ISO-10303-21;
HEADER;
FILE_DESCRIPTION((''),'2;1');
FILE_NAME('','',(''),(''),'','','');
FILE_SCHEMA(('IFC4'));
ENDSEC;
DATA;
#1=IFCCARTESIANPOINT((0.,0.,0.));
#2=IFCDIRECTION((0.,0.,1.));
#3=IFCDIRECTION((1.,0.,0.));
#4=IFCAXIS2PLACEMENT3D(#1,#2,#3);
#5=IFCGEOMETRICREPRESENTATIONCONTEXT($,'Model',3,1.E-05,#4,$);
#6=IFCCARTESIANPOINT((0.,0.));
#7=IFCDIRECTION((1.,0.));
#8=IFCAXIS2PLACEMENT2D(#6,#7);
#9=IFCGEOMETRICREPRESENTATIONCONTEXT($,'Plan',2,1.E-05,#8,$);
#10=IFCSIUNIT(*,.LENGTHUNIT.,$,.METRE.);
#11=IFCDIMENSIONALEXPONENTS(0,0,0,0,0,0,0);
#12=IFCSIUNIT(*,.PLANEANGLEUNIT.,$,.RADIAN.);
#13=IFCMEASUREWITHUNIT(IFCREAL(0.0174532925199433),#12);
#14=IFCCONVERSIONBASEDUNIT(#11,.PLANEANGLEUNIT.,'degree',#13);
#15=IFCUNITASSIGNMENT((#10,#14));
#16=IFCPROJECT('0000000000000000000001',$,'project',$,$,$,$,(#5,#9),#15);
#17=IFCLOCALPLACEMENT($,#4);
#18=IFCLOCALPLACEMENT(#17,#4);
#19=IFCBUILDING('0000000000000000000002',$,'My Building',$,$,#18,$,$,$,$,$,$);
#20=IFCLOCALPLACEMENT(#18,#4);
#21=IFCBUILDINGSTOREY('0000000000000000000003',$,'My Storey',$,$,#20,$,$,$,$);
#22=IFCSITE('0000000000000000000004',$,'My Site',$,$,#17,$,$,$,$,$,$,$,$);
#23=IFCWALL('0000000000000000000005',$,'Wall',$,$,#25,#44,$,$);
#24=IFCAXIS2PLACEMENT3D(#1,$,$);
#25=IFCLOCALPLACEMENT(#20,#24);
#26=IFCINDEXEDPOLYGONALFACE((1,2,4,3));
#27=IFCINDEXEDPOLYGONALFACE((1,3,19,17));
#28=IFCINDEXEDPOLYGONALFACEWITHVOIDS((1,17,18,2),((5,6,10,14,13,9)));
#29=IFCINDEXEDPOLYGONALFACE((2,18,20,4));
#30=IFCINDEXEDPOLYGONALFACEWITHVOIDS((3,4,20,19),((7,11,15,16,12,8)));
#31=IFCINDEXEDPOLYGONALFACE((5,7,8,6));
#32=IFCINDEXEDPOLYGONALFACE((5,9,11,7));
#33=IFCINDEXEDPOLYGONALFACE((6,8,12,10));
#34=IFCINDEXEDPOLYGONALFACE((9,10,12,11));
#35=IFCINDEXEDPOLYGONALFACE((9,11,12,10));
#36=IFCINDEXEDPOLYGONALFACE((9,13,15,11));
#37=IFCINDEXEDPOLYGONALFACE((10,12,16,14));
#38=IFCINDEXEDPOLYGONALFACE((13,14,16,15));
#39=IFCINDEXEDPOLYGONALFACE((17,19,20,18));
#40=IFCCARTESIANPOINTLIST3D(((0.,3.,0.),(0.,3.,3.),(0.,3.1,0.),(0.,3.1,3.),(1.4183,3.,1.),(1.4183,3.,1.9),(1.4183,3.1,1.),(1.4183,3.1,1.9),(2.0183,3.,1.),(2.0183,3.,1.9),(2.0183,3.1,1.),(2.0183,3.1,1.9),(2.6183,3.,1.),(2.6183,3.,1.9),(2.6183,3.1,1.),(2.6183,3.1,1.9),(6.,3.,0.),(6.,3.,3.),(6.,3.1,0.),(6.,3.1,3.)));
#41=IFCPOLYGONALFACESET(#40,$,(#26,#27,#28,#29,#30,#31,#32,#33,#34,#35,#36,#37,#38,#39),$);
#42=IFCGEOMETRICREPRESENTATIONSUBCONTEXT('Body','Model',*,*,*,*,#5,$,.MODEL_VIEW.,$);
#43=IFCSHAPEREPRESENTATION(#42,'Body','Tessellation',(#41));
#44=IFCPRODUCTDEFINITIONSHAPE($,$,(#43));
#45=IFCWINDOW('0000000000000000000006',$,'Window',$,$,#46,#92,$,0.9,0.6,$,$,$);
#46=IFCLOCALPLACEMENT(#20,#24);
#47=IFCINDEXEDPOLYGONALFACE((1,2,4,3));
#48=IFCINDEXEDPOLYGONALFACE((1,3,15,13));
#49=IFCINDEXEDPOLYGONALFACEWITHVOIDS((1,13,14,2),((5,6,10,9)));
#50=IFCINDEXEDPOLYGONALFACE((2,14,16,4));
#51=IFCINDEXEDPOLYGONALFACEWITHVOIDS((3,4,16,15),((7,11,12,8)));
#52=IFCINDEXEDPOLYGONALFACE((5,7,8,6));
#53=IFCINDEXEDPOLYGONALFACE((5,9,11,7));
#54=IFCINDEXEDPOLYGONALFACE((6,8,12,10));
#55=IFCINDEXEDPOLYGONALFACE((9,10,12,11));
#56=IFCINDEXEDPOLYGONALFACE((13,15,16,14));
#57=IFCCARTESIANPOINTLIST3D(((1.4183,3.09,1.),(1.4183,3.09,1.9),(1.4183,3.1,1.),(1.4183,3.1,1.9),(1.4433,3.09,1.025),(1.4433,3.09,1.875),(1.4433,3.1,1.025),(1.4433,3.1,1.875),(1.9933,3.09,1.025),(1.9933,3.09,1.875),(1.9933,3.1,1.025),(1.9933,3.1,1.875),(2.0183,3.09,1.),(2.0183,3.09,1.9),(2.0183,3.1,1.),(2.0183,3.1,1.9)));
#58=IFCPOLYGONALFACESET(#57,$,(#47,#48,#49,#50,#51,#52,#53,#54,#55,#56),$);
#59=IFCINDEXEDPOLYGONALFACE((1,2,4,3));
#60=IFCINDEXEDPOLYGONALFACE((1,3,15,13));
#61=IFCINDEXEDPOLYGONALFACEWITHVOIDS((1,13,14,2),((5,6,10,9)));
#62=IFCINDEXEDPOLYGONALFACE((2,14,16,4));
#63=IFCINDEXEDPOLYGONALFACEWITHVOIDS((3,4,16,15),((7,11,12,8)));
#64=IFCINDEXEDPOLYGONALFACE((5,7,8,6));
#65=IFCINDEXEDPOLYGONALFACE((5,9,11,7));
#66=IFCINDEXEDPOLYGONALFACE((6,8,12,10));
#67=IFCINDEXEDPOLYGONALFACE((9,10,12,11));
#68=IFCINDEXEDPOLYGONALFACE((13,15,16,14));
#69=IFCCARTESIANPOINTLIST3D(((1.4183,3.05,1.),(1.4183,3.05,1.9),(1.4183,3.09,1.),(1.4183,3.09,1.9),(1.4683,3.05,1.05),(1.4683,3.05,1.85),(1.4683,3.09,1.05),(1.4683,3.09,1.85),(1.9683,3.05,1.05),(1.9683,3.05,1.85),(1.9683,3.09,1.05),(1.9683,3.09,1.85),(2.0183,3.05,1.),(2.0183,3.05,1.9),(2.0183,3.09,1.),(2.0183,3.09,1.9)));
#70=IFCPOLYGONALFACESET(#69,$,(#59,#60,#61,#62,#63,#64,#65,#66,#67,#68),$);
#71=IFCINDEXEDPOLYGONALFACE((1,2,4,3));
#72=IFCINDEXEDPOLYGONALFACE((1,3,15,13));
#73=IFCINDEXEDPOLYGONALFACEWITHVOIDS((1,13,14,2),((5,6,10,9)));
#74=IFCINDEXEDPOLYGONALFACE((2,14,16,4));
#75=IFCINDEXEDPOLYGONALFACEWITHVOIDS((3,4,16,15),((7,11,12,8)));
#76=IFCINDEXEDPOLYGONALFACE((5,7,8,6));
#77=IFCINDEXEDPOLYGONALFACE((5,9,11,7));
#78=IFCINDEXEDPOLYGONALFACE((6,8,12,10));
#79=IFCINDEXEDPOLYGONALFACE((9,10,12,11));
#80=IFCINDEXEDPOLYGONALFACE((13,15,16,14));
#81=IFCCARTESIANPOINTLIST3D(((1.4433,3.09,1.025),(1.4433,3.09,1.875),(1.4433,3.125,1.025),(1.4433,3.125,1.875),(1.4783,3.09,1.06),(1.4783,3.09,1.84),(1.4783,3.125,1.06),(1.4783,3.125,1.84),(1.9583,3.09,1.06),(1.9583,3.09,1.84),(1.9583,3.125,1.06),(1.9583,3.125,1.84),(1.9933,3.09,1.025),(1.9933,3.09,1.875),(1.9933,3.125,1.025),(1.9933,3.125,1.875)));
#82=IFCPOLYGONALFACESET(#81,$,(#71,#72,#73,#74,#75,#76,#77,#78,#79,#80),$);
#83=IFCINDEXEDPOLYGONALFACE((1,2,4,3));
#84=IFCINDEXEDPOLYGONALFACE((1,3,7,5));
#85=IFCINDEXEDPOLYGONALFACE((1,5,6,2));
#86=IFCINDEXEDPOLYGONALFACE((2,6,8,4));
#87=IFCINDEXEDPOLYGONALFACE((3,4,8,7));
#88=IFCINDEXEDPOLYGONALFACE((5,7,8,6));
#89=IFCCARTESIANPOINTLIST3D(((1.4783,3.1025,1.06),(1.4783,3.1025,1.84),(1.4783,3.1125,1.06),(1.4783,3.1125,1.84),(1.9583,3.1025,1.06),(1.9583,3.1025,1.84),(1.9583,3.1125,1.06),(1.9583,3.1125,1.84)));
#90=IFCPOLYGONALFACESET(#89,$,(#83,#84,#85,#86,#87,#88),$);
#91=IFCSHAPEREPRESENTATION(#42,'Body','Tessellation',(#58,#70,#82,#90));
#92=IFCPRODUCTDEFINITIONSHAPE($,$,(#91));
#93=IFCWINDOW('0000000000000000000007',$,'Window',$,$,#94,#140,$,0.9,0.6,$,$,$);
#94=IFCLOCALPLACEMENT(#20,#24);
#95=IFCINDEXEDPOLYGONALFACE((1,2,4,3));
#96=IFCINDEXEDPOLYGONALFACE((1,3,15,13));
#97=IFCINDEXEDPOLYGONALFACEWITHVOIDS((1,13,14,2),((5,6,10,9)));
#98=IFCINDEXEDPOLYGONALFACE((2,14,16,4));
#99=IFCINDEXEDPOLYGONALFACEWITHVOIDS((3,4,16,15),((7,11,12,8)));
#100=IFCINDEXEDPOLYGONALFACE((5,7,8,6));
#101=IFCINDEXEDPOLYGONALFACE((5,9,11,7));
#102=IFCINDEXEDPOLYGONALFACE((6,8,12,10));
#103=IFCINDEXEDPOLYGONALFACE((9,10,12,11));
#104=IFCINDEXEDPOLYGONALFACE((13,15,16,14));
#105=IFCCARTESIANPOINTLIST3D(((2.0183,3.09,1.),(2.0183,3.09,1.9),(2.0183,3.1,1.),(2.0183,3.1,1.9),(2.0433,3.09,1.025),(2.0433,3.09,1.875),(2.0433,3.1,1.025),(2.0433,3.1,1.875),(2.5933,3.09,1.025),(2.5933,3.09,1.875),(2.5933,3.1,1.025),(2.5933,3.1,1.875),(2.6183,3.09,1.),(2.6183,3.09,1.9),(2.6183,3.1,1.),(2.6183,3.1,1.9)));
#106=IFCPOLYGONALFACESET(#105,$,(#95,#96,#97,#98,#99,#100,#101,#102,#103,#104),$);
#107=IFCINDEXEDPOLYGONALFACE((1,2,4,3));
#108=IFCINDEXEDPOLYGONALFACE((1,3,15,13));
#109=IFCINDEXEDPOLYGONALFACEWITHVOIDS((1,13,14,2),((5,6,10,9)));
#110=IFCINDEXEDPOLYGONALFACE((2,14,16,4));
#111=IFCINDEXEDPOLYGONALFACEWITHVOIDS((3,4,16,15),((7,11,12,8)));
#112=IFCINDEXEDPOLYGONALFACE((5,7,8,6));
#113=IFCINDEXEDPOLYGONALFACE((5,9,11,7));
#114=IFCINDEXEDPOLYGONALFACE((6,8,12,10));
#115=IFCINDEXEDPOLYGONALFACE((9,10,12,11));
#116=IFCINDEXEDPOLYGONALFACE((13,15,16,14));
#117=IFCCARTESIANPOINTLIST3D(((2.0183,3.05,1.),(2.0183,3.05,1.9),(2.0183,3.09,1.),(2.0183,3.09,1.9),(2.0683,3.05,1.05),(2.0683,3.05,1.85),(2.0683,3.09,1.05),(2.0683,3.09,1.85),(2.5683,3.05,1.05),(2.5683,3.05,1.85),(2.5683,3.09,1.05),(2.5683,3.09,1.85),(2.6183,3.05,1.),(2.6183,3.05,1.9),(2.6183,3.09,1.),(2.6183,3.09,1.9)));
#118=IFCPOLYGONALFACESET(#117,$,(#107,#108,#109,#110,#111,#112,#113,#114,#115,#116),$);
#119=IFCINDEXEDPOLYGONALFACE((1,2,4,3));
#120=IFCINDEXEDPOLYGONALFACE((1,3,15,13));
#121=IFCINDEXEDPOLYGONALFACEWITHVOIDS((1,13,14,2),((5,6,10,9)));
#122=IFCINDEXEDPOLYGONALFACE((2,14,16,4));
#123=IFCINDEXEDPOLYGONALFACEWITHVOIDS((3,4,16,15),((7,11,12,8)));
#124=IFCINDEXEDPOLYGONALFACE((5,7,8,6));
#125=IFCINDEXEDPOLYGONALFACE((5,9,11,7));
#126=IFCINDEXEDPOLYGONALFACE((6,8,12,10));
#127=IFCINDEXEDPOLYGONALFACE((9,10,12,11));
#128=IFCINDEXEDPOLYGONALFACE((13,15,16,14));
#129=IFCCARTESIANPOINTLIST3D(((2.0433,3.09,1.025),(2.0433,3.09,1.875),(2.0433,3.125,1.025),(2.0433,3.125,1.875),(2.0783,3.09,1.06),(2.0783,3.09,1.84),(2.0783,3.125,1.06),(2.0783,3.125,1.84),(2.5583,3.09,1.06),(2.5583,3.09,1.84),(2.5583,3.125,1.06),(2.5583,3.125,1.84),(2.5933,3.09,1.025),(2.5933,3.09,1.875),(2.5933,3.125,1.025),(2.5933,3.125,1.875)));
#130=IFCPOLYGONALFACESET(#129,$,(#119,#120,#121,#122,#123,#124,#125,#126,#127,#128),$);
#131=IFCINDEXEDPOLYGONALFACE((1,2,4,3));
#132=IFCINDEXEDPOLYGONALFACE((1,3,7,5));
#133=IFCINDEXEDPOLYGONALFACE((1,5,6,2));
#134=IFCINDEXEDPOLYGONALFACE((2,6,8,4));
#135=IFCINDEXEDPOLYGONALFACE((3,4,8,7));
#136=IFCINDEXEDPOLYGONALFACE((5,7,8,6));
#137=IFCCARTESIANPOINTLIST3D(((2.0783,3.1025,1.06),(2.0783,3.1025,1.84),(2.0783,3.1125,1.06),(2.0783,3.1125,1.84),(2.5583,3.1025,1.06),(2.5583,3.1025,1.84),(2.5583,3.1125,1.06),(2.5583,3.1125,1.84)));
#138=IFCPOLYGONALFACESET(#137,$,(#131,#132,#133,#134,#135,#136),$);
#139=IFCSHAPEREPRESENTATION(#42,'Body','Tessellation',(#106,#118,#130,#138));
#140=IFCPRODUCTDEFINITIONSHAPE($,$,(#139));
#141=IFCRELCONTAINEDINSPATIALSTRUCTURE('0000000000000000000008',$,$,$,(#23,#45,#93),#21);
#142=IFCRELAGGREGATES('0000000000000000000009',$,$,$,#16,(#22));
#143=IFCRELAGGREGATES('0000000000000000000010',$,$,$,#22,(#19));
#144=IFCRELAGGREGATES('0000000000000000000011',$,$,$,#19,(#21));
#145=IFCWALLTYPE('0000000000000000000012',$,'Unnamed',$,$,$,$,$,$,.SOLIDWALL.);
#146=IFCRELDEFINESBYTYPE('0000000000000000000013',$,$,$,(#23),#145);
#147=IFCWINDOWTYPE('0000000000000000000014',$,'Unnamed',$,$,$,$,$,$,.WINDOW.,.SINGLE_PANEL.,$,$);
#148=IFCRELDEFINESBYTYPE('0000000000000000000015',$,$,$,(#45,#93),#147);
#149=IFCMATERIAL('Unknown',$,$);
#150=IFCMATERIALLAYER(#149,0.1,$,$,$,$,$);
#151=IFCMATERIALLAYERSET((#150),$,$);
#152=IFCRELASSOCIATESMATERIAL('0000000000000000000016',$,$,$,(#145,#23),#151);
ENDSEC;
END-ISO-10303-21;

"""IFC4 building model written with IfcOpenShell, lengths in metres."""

from ifc_helpers import new_model, entity, si_unit, converted_unit, frame, origin_with_axes, origin_2d_with_axis, place, context, subcontext, project, spatial, line, indexed_curve, outline, extrude, shape, source, transform, mapped, material, layer, layer_set, layer_usage, type_object, type_shapes, element, fill, save


model = new_model("IFC4")

# Units and contexts
model_context = context("Model", 3, precision=1e-05, world=origin_with_axes())
plan_context = context("Plan", 2, precision=1e-05, world=origin_2d_with_axis())
body_context_1 = subcontext(model_context, "Body", "Model", "MODEL_VIEW")
body_context_2 = subcontext(plan_context, "Body", "Plan", "PLAN_VIEW")
ifc_project = project(units=[si_unit("LENGTHUNIT", "METRE"), converted_unit("PLANEANGLEUNIT", "degree", entity("IfcReal", 0.0174532925199433), si_unit("PLANEANGLEUNIT", "RADIAN"), dimensions=[0, 0, 0, 0, 0, 0, 0])], contexts=[model_context, plan_context])

# Site, building, storey
site_placement = place(None, origin_with_axes())
site = spatial("IfcSite", under=ifc_project, at=site_placement, Name="My Site")
building_placement = place(site_placement, origin_with_axes())
building = spatial("IfcBuilding", under=site, at=building_placement, Name="My Building")
storey_placement = place(building_placement, origin_with_axes())
storey = spatial("IfcBuildingStorey", under=building, at=storey_placement, Name="My Storey")

# Shared definitions
ifc_material = material(Name="Unknown")

# Shared definitions
ifc_layer = layer(ifc_material, 0.1)
ifc_layer_set = layer_set([ifc_layer])
wall_type = type_object("IfcWallType", Name="Unnamed", PredefinedType="SOLIDWALL", material=ifc_layer_set)
shared_shape_1 = source(origin_with_axes(), body_context_1, "Body", "SweptSolid", [
    extrude(outline(indexed_curve([(0.0, 0.0), (0.6, 0.0), (0.6, 0.9), (0.0, 0.9)], segments=[line(1, 2, 3, 4, 1)])), frame((0.0, -0.6, 0.0), z_axis=(0.0, -1.0, 0.0), x_axis=(1.0, 0.0, 0.0)), (0.0, 0.0, -1.0), 1.2),
])
window_type = type_object("IfcWindowType", Name="Unnamed", PartitioningType="SINGLE_PANEL", PredefinedType="WINDOW")
shared_shape_2 = source(origin_with_axes(), body_context_1, "Body", "SweptSolid", [
    extrude(outline(indexed_curve([(0.0, 0.0), (0.6, 0.0), (0.6, 0.9), (0.0, 0.9)], segments=[line(1, 2, 3, 4, 1)]), holes=[indexed_curve([(0.025, 0.025), (0.575, 0.025), (0.575, 0.875), (0.025, 0.875)], segments=[line(1, 2, 3, 4, 1)])]), frame((0.0, 0.09, 0.0), z_axis=(0.0, -1.0, 0.0), x_axis=(1.0, 0.0, 0.0)), (0.0, 0.0, -1.0), 0.01),
    extrude(outline(indexed_curve([(0.0, 0.0), (0.6, 0.0), (0.6, 0.9), (0.0, 0.9)], segments=[line(1, 2, 3, 4, 1)]), holes=[indexed_curve([(0.05, 0.05), (0.55, 0.05), (0.55, 0.85), (0.05, 0.85)], segments=[line(1, 2, 3, 4, 1)])]), frame((0.0, 0.05, 0.0), z_axis=(0.0, -1.0, 0.0), x_axis=(1.0, 0.0, 0.0)), (0.0, 0.0, -1.0), 0.04),
    extrude(outline(indexed_curve([(0.0, 0.0), (0.55, 0.0), (0.55, 0.85), (0.0, 0.85)], segments=[line(1, 2, 3, 4, 1)]), holes=[indexed_curve([(0.035, 0.035), (0.515, 0.035), (0.515, 0.815), (0.035, 0.815)], segments=[line(1, 2, 3, 4, 1)])]), frame((0.025, 0.09, 0.025), z_axis=(0.0, -1.0, 0.0), x_axis=(1.0, 0.0, 0.0)), (0.0, 0.0, -1.0), 0.035),
    extrude(outline(indexed_curve([(0.035, 0.035), (0.515, 0.035), (0.515, 0.815), (0.035, 0.815)], segments=[line(1, 2, 3, 4, 1)])), frame((0.025, 0.1025, 0.025), z_axis=(0.0, -1.0, 0.0), x_axis=(1.0, 0.0, 0.0)), (0.0, 0.0, -1.0), 0.01),
])
shared_shape_3 = source(origin_with_axes(), body_context_2, "Body", "Curve2D", [
    entity("IfcIndexedPolyCurve", entity("IfcCartesianPointList2D", [[0.05, 0.05], [0.55, 0.05]])),
    entity("IfcIndexedPolyCurve", entity("IfcCartesianPointList2D", [[0.0, 0.1], [0.025, 0.1], [0.025, 0.09], [0.05, 0.09], [0.05, 0.05], [0.0, 0.05]]), [entity("IfcLineIndex", [1, 2, 3, 4, 5, 6, 1])]),
    entity("IfcIndexedPolyCurve", entity("IfcCartesianPointList2D", [[0.6, 0.1], [0.575, 0.1], [0.575, 0.09], [0.55, 0.09], [0.55, 0.05], [0.6, 0.05]]), [entity("IfcLineIndex", [1, 2, 3, 4, 5, 6, 1])]),
    entity("IfcIndexedPolyCurve", entity("IfcCartesianPointList2D", [[0.025, 0.09], [0.06, 0.09], [0.06, 0.125], [0.025, 0.125]]), [entity("IfcLineIndex", [1, 2, 3, 4, 1])]),
    entity("IfcIndexedPolyCurve", entity("IfcCartesianPointList2D", [[0.575, 0.09], [0.54, 0.09], [0.54, 0.125], [0.575, 0.125]]), [entity("IfcLineIndex", [1, 2, 3, 4, 1])]),
    entity("IfcIndexedPolyCurve", entity("IfcCartesianPointList2D", [[0.06, 0.09], [0.54, 0.09]])),
    entity("IfcIndexedPolyCurve", entity("IfcCartesianPointList2D", [[0.06, 0.125], [0.54, 0.125]])),
    entity("IfcIndexedPolyCurve", entity("IfcCartesianPointList2D", [[0.06, 0.1075], [0.54, 0.1075]])),
])
type_shapes(window_type, [shared_shape_2, shared_shape_3])

# Wall, openings, windows
ifc_layer_usage_1 = layer_usage(ifc_layer_set, "AXIS2", "POSITIVE", 0.0)
wall_1_placement = place(storey_placement, frame((0.0, 3.0, 0.0), z_axis=(0.0, 0.0, 1.0), x_axis=(1.0, 0.0, 0.0)))
wall_1 = element("IfcWall", 1, at=wall_1_placement, inside=storey, type_object=wall_type, material=ifc_layer_usage_1, Name="Wall", context=body_context_1, shape_type="SweptSolid", body=[
    extrude(outline(indexed_curve([(0.0, 0.0), (0.0, 0.1), (6.0, 0.1), (6.0, 0.0)], segments=[line(1, 2, 3, 4, 1)])), origin_with_axes(), (0.0, 0.0, 1.0), 3.0),
])
opening_1_placement = place(wall_1_placement, frame((1.4183, 0.0, 1.0), z_axis=(0.0, 0.0, 1.0), x_axis=(1.0, 0.0, 0.0)))
opening_1 = element("IfcOpeningElement", 2, at=opening_1_placement, cuts=wall_1, PredefinedType="OPENING", context=body_context_1, shape_type="MappedRepresentation", body=[
    mapped(shared_shape_1, transform((0.0, 0.0, 0.0), x_axis=(1.0, 0.0, 0.0), y_axis=(0.0, 1.0, 0.0), z_axis=(0.0, 0.0, 1.0), scale=1.0)),
])
opening_2_placement = place(wall_1_placement, frame((2.0183, 0.0, 1.0), z_axis=(0.0, 0.0, 1.0), x_axis=(1.0, 0.0, 0.0)))
opening_2 = element("IfcOpeningElement", 3, at=opening_2_placement, cuts=wall_1, PredefinedType="OPENING", context=body_context_1, shape_type="MappedRepresentation", body=[
    mapped(shared_shape_1, transform((0.0, 0.0, 0.0), x_axis=(1.0, 0.0, 0.0), y_axis=(0.0, 1.0, 0.0), z_axis=(0.0, 0.0, 1.0), scale=1.0)),
])
window_1_placement = place(opening_1_placement, origin_with_axes())
window_1 = element("IfcWindow", 4, at=window_1_placement, inside=storey, type_object=window_type, Name="Window", OverallHeight=0.9, OverallWidth=0.6, shapes=[
    shape(body_context_1, "Body", "MappedRepresentation", [mapped(shared_shape_2, transform((0.0, 0.0, 0.0), x_axis=(1.0, 0.0, 0.0), y_axis=(0.0, 1.0, 0.0), z_axis=(0.0, 0.0, 1.0), scale=1.0))]),
    shape(body_context_2, "Body", "MappedRepresentation", [mapped(shared_shape_3, transform((0.0, 0.0, 0.0), x_axis=(1.0, 0.0, 0.0), y_axis=(0.0, 1.0, 0.0), z_axis=(0.0, 0.0, 1.0), scale=1.0))]),
])
fill(opening_1, window_1)
window_2_placement = place(opening_2_placement, origin_with_axes())
window_2 = element("IfcWindow", 5, at=window_2_placement, inside=storey, type_object=window_type, Name="Window", OverallHeight=0.9, OverallWidth=0.6, shapes=[
    shape(body_context_1, "Body", "MappedRepresentation", [mapped(shared_shape_2, transform((0.0, 0.0, 0.0), x_axis=(1.0, 0.0, 0.0), y_axis=(0.0, 1.0, 0.0), z_axis=(0.0, 0.0, 1.0), scale=1.0))]),
    shape(body_context_2, "Body", "MappedRepresentation", [mapped(shared_shape_3, transform((0.0, 0.0, 0.0), x_axis=(1.0, 0.0, 0.0), y_axis=(0.0, 1.0, 0.0), z_axis=(0.0, 0.0, 1.0), scale=1.0))]),
])
fill(opening_2, window_2)

save(model, "model.ifc")
